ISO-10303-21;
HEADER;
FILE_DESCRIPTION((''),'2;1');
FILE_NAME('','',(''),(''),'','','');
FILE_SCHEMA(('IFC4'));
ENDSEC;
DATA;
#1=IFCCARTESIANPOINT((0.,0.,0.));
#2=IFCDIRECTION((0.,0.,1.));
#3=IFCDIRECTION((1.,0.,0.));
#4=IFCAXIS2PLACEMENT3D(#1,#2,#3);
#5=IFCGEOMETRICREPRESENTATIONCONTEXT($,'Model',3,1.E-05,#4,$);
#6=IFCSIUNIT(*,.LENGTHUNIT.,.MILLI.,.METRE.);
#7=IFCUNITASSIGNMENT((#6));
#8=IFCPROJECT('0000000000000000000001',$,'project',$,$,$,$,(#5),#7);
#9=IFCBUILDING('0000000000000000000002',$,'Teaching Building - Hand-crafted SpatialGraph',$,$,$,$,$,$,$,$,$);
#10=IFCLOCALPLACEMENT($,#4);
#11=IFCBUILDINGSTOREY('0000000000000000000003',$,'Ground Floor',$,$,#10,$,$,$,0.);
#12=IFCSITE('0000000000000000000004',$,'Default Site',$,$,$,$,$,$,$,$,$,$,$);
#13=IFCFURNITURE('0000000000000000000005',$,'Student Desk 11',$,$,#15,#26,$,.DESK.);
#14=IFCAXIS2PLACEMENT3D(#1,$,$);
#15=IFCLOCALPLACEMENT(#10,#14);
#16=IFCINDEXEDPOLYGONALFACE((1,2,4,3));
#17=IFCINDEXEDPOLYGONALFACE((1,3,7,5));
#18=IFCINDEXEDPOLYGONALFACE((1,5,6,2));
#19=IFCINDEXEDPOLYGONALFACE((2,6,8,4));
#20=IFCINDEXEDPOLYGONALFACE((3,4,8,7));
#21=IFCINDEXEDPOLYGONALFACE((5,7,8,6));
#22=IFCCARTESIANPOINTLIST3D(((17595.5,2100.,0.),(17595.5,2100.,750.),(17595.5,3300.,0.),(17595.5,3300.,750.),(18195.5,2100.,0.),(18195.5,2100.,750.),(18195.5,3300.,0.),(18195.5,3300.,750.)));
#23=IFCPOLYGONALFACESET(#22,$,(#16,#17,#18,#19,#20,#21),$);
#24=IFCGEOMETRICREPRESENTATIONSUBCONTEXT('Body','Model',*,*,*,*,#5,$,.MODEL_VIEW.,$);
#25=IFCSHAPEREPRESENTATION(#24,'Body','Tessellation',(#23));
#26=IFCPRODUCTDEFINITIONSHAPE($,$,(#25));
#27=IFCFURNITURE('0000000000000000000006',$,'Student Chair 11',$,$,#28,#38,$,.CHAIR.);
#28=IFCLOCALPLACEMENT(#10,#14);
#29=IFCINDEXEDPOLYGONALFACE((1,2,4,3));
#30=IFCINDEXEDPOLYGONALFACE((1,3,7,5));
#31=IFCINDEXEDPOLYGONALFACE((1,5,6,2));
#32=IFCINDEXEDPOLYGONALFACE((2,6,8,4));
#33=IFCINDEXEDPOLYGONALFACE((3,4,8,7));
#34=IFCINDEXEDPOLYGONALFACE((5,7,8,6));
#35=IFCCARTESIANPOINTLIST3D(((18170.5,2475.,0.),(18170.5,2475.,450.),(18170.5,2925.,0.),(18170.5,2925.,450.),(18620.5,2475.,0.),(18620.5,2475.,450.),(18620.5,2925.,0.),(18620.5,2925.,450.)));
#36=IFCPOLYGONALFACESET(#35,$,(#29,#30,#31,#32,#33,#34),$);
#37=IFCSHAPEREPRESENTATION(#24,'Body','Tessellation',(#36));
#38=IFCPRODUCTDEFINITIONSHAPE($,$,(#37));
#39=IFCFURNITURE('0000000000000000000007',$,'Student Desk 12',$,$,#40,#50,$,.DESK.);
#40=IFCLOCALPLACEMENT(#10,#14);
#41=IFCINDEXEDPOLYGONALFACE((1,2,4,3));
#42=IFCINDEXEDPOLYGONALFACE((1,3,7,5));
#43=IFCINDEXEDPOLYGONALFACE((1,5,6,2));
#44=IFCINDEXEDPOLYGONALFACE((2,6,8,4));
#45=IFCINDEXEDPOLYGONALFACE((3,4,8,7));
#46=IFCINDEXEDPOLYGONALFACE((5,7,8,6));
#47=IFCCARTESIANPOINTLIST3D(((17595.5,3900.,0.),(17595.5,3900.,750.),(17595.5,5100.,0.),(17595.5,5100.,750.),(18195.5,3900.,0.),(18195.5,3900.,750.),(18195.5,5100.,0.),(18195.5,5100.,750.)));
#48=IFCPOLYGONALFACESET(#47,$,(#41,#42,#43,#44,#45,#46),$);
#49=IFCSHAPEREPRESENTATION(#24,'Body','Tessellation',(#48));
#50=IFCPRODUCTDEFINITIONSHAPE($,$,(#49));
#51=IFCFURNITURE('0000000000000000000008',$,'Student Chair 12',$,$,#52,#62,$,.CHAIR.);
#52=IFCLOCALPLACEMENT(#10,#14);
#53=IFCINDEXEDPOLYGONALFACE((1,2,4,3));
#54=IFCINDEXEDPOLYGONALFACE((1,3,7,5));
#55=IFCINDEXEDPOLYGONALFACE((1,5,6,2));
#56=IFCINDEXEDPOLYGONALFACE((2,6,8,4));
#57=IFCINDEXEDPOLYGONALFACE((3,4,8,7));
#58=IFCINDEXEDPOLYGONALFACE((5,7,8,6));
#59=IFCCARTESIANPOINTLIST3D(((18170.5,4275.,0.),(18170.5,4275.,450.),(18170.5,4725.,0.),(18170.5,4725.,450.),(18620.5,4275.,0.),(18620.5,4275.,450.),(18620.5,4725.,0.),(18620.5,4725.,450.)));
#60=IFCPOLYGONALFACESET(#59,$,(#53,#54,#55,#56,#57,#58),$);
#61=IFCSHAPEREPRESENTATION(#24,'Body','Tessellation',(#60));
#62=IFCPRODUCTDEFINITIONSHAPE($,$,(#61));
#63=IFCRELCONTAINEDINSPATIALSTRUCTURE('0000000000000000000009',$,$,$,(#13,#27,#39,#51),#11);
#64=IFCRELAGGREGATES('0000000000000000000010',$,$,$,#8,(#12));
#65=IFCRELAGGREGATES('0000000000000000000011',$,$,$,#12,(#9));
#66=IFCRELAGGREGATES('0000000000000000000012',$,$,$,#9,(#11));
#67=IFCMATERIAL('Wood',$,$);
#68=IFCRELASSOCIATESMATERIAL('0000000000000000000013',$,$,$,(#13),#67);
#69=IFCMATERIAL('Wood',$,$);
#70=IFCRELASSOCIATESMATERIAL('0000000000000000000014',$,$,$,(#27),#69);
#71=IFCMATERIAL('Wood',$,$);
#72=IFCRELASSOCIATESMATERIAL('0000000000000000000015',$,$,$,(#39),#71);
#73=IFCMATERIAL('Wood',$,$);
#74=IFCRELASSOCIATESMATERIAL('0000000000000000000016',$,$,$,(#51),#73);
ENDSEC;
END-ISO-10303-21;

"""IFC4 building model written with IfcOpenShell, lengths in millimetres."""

from ifc_helpers import new_model, si_unit, frame, origin_with_axes, origin_2d, place, context, subcontext, project, spatial, rectangle, extrude, material, element, save


model = new_model("IFC4")

# Units and contexts
model_context = context("Model", 3, precision=1e-05, world=origin_with_axes())
body_context = subcontext(model_context, "Body", "Model", "MODEL_VIEW")
ifc_project = project(units=[si_unit("LENGTHUNIT", "METRE", prefix="MILLI")], contexts=[model_context])

# Site, building, storey
site = spatial("IfcSite", under=ifc_project, Name="Default Site")
building = spatial("IfcBuilding", under=site, Name="Teaching Building - Hand-crafted SpatialGraph")
storey_placement = place(None, origin_with_axes())
storey = spatial("IfcBuildingStorey", under=building, at=storey_placement, Name="Ground Floor", Elevation=0.0)

# Furniture
ifc_material_1 = material(Name="Wood")
furniture_1_placement = place(storey_placement, frame((17895.5, 2700.0, 0.0), z_axis=(0.0, 0.0, 1.0), x_axis=(0.0, 1.0, 0.0)))
element("IfcFurniture", 1, at=furniture_1_placement, inside=storey, material=ifc_material_1, Name="Student Desk 11", PredefinedType="DESK", context=body_context, shape_type="SweptSolid", body=[
    extrude(rectangle(XDim=1200.0, YDim=600.0, at=origin_2d()), origin_with_axes(), (0.0, 0.0, 1.0), 750.0),
])
ifc_material_2 = material(Name="Wood")
furniture_2_placement = place(storey_placement, frame((18395.5, 2700.0, 0.0), z_axis=(0.0, 0.0, 1.0), x_axis=(1.0, 0.0, 0.0)))
element("IfcFurniture", 2, at=furniture_2_placement, inside=storey, material=ifc_material_2, Name="Student Chair 11", PredefinedType="CHAIR", context=body_context, shape_type="SweptSolid", body=[
    extrude(rectangle(XDim=450.0, YDim=450.0, at=origin_2d()), origin_with_axes(), (0.0, 0.0, 1.0), 450.0),
])
ifc_material_3 = material(Name="Wood")
furniture_3_placement = place(storey_placement, frame((17895.5, 4500.0, 0.0), z_axis=(0.0, 0.0, 1.0), x_axis=(0.0, 1.0, 0.0)))
element("IfcFurniture", 3, at=furniture_3_placement, inside=storey, material=ifc_material_3, Name="Student Desk 12", PredefinedType="DESK", context=body_context, shape_type="SweptSolid", body=[
    extrude(rectangle(XDim=1200.0, YDim=600.0, at=origin_2d()), origin_with_axes(), (0.0, 0.0, 1.0), 750.0),
])
ifc_material_4 = material(Name="Wood")
furniture_4_placement = place(storey_placement, frame((18395.5, 4500.0, 0.0), z_axis=(0.0, 0.0, 1.0), x_axis=(1.0, 0.0, 0.0)))
element("IfcFurniture", 4, at=furniture_4_placement, inside=storey, material=ifc_material_4, Name="Student Chair 12", PredefinedType="CHAIR", context=body_context, shape_type="SweptSolid", body=[
    extrude(rectangle(XDim=450.0, YDim=450.0, at=origin_2d()), origin_with_axes(), (0.0, 0.0, 1.0), 450.0),
])

save(model, "model.ifc")
